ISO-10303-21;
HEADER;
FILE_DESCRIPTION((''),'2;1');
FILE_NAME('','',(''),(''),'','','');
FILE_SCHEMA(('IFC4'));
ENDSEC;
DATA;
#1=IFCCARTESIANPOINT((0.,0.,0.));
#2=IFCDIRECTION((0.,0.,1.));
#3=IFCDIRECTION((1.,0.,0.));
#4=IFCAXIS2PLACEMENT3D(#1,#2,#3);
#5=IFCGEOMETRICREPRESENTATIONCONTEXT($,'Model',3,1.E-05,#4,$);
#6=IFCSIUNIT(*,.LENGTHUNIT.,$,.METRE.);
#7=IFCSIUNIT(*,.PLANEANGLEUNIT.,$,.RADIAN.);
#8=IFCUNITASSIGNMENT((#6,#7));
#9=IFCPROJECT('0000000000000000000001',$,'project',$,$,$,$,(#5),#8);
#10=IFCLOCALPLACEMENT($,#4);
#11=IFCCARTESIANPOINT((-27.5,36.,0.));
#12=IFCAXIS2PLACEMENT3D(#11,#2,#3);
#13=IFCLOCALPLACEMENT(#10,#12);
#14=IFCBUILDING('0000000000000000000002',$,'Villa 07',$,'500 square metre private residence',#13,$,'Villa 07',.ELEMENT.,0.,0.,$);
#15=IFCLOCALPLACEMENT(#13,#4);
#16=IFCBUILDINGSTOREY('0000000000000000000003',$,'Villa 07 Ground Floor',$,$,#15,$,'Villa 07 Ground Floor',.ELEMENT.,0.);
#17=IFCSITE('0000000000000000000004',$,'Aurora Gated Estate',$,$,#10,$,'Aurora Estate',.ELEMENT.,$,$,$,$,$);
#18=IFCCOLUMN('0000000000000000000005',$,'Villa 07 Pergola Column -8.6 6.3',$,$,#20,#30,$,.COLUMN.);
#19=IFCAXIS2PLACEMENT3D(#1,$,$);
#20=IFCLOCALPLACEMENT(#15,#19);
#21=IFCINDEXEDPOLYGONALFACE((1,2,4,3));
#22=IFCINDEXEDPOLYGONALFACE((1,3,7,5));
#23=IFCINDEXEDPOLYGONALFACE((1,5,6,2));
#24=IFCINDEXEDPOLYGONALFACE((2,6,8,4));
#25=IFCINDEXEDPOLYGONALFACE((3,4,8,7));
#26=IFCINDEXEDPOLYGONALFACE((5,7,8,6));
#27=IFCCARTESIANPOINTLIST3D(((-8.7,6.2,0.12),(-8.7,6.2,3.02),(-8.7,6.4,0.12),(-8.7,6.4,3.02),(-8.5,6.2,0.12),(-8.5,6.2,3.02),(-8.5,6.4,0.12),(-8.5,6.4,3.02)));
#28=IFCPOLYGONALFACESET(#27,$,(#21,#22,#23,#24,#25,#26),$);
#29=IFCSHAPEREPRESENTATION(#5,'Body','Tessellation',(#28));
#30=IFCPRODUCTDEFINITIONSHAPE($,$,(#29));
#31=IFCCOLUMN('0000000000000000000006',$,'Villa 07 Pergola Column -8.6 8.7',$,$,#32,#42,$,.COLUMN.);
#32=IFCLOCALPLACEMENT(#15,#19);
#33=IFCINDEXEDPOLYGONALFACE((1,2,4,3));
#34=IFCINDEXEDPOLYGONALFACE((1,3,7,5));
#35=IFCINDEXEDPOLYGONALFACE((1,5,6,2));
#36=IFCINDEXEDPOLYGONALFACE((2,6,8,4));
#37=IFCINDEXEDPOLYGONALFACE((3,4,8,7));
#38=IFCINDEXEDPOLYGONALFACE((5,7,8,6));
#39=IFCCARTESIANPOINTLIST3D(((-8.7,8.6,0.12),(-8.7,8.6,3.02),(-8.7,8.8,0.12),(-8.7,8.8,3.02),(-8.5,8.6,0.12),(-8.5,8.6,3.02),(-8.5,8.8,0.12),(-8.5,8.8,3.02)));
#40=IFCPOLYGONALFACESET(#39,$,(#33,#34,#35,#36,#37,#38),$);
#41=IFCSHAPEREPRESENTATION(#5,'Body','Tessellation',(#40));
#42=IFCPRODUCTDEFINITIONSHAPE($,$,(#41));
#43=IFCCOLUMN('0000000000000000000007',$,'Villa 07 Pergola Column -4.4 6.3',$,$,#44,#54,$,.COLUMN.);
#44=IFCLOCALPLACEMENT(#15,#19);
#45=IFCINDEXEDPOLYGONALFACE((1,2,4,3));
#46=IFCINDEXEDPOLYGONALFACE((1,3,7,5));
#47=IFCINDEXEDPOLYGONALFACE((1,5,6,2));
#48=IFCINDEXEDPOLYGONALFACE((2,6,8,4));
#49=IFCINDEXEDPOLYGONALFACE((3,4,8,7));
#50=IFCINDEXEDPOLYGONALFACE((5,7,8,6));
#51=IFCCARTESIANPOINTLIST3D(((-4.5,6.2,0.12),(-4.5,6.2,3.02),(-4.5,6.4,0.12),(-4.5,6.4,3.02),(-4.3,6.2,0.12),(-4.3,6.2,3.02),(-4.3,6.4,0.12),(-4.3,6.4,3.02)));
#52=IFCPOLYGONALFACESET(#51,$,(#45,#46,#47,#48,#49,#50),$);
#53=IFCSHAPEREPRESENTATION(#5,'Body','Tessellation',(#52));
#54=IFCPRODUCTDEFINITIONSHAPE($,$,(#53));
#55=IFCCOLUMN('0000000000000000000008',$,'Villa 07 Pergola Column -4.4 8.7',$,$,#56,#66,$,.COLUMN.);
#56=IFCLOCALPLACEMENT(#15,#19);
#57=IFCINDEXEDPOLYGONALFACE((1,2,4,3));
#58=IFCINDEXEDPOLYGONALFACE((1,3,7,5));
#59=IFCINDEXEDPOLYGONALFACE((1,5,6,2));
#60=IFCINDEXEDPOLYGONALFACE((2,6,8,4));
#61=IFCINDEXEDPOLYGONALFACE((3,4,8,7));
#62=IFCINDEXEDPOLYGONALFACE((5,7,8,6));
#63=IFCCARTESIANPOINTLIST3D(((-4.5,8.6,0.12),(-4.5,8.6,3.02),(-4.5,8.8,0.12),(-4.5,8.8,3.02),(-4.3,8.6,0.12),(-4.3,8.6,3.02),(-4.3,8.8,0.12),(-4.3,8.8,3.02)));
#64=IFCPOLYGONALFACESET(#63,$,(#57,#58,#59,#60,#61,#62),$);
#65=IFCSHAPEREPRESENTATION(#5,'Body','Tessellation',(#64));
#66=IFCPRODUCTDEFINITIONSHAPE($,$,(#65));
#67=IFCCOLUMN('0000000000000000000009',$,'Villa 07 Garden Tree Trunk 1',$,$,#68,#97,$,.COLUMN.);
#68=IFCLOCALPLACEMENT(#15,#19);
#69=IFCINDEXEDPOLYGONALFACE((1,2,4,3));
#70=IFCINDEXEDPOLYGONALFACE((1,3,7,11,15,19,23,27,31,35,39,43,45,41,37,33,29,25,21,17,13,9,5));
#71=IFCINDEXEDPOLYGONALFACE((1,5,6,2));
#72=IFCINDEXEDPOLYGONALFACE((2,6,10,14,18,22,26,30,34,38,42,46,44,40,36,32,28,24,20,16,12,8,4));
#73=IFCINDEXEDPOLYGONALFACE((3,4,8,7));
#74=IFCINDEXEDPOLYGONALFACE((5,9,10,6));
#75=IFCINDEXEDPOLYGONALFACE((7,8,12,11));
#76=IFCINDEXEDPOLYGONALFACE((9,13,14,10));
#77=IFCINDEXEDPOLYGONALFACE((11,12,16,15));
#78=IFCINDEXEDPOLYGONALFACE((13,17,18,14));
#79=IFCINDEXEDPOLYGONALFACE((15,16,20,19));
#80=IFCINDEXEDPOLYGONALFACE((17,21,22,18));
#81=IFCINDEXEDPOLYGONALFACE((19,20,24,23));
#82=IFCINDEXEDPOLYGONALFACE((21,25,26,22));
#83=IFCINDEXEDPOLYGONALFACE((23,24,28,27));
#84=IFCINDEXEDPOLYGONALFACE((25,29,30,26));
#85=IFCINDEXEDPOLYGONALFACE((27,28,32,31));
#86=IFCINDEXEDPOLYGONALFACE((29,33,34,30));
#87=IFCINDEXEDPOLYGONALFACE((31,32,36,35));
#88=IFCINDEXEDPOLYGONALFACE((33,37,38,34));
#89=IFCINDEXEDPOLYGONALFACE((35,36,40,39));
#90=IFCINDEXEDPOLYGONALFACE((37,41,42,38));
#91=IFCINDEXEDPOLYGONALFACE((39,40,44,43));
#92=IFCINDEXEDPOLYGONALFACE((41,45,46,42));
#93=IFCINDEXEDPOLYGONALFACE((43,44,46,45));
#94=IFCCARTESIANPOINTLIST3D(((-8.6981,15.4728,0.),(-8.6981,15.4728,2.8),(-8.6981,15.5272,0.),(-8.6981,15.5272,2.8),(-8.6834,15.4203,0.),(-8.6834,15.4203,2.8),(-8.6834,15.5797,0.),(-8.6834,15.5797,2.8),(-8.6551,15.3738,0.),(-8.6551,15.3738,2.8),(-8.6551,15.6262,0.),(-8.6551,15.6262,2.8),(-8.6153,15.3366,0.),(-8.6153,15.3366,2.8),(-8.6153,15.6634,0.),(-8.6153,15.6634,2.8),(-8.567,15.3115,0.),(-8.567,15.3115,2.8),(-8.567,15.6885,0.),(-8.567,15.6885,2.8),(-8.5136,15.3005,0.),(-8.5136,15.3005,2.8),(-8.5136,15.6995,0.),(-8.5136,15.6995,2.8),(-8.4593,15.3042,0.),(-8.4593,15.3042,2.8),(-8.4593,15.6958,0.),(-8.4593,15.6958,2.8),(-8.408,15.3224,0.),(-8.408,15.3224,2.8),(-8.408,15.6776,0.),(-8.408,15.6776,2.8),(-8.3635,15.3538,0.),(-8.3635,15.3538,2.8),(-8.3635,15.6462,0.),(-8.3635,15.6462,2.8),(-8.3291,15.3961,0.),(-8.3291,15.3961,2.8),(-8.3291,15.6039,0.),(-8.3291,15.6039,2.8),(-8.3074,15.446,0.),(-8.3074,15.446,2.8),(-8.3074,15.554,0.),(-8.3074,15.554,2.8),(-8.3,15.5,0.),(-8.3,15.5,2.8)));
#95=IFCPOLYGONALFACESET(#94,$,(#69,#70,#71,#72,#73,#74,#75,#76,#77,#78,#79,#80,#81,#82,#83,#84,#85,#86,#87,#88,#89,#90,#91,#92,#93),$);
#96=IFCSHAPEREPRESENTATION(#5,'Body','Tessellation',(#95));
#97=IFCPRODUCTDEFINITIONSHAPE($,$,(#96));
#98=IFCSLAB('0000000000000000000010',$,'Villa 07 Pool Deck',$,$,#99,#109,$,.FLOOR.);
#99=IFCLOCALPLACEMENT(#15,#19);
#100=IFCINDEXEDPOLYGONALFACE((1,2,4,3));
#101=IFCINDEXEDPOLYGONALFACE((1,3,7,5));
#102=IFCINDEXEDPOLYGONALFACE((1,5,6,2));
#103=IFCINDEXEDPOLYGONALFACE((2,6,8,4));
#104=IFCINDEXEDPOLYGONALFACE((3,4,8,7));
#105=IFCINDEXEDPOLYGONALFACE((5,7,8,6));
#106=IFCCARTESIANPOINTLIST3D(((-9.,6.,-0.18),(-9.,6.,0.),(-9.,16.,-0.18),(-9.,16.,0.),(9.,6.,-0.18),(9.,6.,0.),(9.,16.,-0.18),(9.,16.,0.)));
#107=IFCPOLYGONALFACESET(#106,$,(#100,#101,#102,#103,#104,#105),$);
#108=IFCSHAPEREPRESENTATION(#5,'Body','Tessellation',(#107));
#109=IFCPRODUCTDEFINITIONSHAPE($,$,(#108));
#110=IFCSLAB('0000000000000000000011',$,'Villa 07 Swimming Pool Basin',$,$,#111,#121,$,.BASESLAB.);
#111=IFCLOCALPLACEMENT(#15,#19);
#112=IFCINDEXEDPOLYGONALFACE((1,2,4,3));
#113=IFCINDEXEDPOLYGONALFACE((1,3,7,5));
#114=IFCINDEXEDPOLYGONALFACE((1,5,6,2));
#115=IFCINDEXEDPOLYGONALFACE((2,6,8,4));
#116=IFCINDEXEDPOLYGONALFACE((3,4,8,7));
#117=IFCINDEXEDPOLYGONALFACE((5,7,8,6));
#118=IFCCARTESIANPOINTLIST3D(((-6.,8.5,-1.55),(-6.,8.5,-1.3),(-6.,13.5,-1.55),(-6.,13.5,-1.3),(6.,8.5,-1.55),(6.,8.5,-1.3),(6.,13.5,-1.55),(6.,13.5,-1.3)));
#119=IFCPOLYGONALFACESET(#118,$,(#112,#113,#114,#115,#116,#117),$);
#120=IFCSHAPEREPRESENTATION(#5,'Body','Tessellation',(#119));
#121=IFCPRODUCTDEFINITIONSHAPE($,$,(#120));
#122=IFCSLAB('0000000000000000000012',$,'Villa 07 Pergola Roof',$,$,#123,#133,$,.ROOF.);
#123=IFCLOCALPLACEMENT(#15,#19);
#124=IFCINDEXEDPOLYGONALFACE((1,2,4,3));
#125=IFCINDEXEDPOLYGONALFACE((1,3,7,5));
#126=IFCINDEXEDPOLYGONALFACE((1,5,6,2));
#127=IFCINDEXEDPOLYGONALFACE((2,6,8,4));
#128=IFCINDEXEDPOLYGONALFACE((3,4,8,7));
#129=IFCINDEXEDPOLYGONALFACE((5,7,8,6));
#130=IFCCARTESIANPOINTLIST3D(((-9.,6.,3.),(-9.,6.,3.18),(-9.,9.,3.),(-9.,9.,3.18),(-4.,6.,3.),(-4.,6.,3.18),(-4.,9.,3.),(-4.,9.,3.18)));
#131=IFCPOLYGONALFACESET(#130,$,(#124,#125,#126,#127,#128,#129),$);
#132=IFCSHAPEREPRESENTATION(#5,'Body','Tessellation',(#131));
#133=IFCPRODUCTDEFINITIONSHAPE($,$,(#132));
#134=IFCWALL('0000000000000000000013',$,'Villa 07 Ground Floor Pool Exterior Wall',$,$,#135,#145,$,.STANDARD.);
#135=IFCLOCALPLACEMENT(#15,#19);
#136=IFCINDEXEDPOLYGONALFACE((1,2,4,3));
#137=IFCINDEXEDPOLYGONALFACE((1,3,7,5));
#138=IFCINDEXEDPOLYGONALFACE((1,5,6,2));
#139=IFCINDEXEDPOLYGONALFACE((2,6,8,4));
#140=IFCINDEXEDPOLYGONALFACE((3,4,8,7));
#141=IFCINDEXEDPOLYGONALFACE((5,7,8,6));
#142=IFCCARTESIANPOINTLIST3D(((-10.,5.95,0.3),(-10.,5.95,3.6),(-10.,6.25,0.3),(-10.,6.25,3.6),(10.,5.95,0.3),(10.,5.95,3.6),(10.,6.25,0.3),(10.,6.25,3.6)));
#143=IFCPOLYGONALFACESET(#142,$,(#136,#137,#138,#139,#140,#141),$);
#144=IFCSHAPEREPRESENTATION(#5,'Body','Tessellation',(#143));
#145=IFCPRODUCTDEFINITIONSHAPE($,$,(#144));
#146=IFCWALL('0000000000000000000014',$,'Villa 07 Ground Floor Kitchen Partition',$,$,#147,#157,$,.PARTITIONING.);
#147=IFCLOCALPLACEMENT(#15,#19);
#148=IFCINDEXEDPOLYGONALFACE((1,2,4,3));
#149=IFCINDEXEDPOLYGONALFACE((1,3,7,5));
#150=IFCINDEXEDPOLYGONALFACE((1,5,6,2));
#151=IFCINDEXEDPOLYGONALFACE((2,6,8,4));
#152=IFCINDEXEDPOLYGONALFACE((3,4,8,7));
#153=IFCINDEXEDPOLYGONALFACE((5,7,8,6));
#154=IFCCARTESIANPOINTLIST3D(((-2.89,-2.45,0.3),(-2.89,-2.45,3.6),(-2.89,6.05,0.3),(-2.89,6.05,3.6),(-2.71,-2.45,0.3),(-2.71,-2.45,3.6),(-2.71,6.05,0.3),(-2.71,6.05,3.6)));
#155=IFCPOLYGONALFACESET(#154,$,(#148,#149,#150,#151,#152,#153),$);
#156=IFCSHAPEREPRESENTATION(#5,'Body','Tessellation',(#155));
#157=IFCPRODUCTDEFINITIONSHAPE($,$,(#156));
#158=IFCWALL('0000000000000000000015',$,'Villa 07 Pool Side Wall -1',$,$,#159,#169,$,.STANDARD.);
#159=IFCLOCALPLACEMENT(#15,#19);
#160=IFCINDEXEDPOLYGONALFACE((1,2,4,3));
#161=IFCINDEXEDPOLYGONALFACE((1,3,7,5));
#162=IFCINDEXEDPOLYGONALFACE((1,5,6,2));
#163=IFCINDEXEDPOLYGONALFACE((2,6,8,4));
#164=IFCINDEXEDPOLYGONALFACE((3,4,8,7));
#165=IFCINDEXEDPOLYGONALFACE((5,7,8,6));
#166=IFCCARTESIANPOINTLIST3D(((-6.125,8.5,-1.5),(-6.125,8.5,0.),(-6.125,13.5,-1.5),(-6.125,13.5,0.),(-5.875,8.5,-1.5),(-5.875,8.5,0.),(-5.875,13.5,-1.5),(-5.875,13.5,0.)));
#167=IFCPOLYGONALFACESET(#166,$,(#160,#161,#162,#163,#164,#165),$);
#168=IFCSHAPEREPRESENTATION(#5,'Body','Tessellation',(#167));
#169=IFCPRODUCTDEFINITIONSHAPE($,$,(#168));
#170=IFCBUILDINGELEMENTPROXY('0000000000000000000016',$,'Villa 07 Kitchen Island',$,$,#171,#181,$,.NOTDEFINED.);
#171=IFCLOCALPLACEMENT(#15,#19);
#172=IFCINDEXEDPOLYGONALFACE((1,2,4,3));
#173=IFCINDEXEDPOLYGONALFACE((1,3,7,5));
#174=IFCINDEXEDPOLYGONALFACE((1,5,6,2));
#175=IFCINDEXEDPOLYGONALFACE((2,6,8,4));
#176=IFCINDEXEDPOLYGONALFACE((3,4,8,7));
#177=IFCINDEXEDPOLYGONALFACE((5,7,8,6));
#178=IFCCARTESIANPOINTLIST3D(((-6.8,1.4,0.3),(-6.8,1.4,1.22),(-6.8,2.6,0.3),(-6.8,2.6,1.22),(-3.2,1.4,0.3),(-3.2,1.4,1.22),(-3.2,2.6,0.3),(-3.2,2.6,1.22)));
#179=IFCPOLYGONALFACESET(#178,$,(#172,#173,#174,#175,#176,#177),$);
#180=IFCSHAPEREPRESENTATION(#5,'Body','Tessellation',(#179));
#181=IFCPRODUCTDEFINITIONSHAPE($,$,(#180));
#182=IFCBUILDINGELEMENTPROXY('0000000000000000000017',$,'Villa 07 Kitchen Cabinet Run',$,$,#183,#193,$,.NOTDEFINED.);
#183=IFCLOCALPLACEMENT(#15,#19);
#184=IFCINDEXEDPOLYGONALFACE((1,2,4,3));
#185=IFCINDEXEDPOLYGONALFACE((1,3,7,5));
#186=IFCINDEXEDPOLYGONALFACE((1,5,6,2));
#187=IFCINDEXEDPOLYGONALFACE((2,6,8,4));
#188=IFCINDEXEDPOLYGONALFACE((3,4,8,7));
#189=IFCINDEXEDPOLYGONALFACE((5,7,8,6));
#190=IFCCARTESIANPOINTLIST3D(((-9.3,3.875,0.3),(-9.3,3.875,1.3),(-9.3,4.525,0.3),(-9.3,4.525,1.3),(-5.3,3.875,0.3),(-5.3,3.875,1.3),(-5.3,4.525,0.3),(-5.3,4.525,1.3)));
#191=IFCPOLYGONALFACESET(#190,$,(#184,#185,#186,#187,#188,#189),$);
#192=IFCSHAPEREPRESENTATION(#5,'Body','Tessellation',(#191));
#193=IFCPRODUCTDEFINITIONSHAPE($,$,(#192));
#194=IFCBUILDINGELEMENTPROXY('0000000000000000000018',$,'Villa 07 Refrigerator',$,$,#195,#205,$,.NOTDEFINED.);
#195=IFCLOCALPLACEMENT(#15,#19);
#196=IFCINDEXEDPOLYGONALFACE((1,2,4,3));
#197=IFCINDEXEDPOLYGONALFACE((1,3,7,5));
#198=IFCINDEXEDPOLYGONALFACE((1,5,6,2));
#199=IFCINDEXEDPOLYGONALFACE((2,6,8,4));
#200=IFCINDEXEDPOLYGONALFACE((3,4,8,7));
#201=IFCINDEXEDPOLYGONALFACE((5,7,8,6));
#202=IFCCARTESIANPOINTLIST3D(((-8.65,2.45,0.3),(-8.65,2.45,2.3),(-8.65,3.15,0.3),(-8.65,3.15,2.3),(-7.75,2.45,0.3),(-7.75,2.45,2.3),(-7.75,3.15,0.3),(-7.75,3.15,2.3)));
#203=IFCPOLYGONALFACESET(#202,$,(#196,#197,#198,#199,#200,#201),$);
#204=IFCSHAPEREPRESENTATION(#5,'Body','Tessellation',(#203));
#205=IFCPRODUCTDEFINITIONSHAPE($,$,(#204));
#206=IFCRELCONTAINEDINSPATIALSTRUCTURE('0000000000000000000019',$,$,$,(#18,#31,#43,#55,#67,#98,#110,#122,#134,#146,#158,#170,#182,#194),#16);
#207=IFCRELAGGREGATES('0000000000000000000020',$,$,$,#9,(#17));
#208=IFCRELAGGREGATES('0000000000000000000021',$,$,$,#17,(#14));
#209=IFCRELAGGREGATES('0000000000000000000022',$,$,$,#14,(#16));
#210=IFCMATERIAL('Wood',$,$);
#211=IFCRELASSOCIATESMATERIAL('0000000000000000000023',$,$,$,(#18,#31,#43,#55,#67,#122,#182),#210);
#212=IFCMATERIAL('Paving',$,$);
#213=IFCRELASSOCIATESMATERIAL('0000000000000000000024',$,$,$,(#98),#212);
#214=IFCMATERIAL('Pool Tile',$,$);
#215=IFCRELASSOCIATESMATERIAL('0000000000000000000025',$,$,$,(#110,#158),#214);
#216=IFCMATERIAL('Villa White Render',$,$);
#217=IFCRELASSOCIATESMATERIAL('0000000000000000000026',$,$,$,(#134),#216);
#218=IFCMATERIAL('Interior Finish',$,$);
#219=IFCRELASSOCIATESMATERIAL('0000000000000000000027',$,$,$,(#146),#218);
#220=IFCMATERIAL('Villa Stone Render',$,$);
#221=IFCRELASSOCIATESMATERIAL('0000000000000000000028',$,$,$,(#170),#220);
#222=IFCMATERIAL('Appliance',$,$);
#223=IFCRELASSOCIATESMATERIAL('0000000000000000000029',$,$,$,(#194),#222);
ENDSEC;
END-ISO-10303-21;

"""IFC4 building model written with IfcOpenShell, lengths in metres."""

from ifc_helpers import new_model, si_unit, frame, origin_with_axes, origin_2d_with_axis, place, context, project, spatial, rectangle, circle, extrude, material, element, save


model = new_model("IFC4")

# Units and contexts
model_context = context("Model", 3, precision=1e-05, world=origin_with_axes())
ifc_project = project(units=[si_unit("LENGTHUNIT", "METRE"), si_unit("PLANEANGLEUNIT", "RADIAN")], contexts=[model_context])

# Site, building, storey
site_placement = place(None, origin_with_axes())
site = spatial("IfcSite", under=ifc_project, at=site_placement, Name="Aurora Gated Estate", LongName="Aurora Estate", CompositionType="ELEMENT")
building_placement = place(site_placement, frame((-27.5, 36.0, 0.0), z_axis=(0.0, 0.0, 1.0), x_axis=(1.0, 0.0, 0.0)))
building = spatial("IfcBuilding", under=site, at=building_placement, Name="Villa 07", ObjectType="500 square metre private residence", LongName="Villa 07", CompositionType="ELEMENT", ElevationOfRefHeight=0.0, ElevationOfTerrain=0.0)
storey_placement = place(building_placement, origin_with_axes())
storey = spatial("IfcBuildingStorey", under=building, at=storey_placement, Name="Villa 07 Ground Floor", LongName="Villa 07 Ground Floor", CompositionType="ELEMENT", Elevation=0.0)

# Columns
ifc_material_1 = material(Name="Wood")
for number, where, z_axis, x_axis, name in (
    (1, (-8.6, 6.3, 0.12), (0.0, 0.0, 1.0), (1.0, 0.0, 0.0), "Villa 07 Pergola Column -8.6 6.3"),
    (2, (-8.6, 8.7, 0.12), (0.0, 0.0, 1.0), (1.0, 0.0, 0.0), "Villa 07 Pergola Column -8.6 8.7"),
    (3, (-4.4, 6.3, 0.12), (0.0, 0.0, 1.0), (1.0, 0.0, 0.0), "Villa 07 Pergola Column -4.4 6.3"),
    (4, (-4.4, 8.7, 0.12), (0.0, 0.0, 1.0), (1.0, 0.0, 0.0), "Villa 07 Pergola Column -4.4 8.7"),
):
    element("IfcColumn", number, at=place(storey_placement, frame(where, z_axis=z_axis, x_axis=x_axis)), inside=storey, material=ifc_material_1, Name=name, PredefinedType="COLUMN", context=model_context, shape_type="SweptSolid", body=[
        extrude(rectangle(XDim=0.2, YDim=0.2, at=origin_2d_with_axis()), origin_with_axes(), (0.0, 0.0, 1.0), 2.9),
    ])
column_placement = place(storey_placement, frame((-8.5, 15.5, 0.0), z_axis=(0.0, 0.0, 1.0), x_axis=(1.0, 0.0, 0.0)))
element("IfcColumn", 5, at=column_placement, inside=storey, material=ifc_material_1, Name="Villa 07 Garden Tree Trunk 1", PredefinedType="COLUMN", context=model_context, shape_type="SweptSolid", body=[
    extrude(circle(Radius=0.2, at=origin_2d_with_axis()), origin_with_axes(), (0.0, 0.0, 1.0), 2.8),
])

# Slabs
ifc_material_2 = material(Name="Paving")
slab_1_placement = place(storey_placement, frame((0.0, 11.0, -0.18), z_axis=(0.0, 0.0, 1.0), x_axis=(1.0, 0.0, 0.0)))
element("IfcSlab", 6, at=slab_1_placement, inside=storey, material=ifc_material_2, Name="Villa 07 Pool Deck", PredefinedType="FLOOR", context=model_context, shape_type="SweptSolid", body=[
    extrude(rectangle(XDim=18.0, YDim=10.0, at=origin_2d_with_axis()), origin_with_axes(), (0.0, 0.0, 1.0), 0.18),
])
ifc_material_3 = material(Name="Pool Tile")
slab_2_placement = place(storey_placement, frame((0.0, 11.0, -1.55), z_axis=(0.0, 0.0, 1.0), x_axis=(1.0, 0.0, 0.0)))
element("IfcSlab", 7, at=slab_2_placement, inside=storey, material=ifc_material_3, Name="Villa 07 Swimming Pool Basin", PredefinedType="BASESLAB", context=model_context, shape_type="SweptSolid", body=[
    extrude(rectangle(XDim=12.0, YDim=5.0, at=origin_2d_with_axis()), origin_with_axes(), (0.0, 0.0, 1.0), 0.25),
])
slab_3_placement = place(storey_placement, frame((-6.5, 7.5, 3.0), z_axis=(0.0, 0.0, 1.0), x_axis=(1.0, 0.0, 0.0)))
element("IfcSlab", 8, at=slab_3_placement, inside=storey, material=ifc_material_1, Name="Villa 07 Pergola Roof", PredefinedType="ROOF", context=model_context, shape_type="SweptSolid", body=[
    extrude(rectangle(XDim=5.0, YDim=3.0, at=origin_2d_with_axis()), origin_with_axes(), (0.0, 0.0, 1.0), 0.18),
])

# Walls
ifc_material_4 = material(Name="Villa White Render")
wall_1_placement = place(storey_placement, frame((0.0, 6.1, 0.3), z_axis=(0.0, 0.0, 1.0), x_axis=(1.0, 0.0, 0.0)))
element("IfcWall", 9, at=wall_1_placement, inside=storey, material=ifc_material_4, Name="Villa 07 Ground Floor Pool Exterior Wall", PredefinedType="STANDARD", context=model_context, shape_type="SweptSolid", body=[
    extrude(rectangle(XDim=20.0, YDim=0.3, at=origin_2d_with_axis()), origin_with_axes(), (0.0, 0.0, 1.0), 3.3),
])
ifc_material_5 = material(Name="Interior Finish")
wall_2_placement = place(storey_placement, frame((-2.8, 1.8, 0.3), z_axis=(0.0, 0.0, 1.0), x_axis=(1.0, 0.0, 0.0)))
element("IfcWall", 10, at=wall_2_placement, inside=storey, material=ifc_material_5, Name="Villa 07 Ground Floor Kitchen Partition", PredefinedType="PARTITIONING", context=model_context, shape_type="SweptSolid", body=[
    extrude(rectangle(XDim=0.18, YDim=8.5, at=origin_2d_with_axis()), origin_with_axes(), (0.0, 0.0, 1.0), 3.3),
])
wall_3_placement = place(storey_placement, frame((-6.0, 11.0, -1.5), z_axis=(0.0, 0.0, 1.0), x_axis=(1.0, 0.0, 0.0)))
element("IfcWall", 11, at=wall_3_placement, inside=storey, material=ifc_material_3, Name="Villa 07 Pool Side Wall -1", PredefinedType="STANDARD", context=model_context, shape_type="SweptSolid", body=[
    extrude(rectangle(XDim=0.25, YDim=5.0, at=origin_2d_with_axis()), origin_with_axes(), (0.0, 0.0, 1.0), 1.5),
])

# Building element proxies
ifc_material_6 = material(Name="Villa Stone Render")
proxy_1_placement = place(storey_placement, frame((-5.0, 2.0, 0.3), z_axis=(0.0, 0.0, 1.0), x_axis=(1.0, 0.0, 0.0)))
element("IfcBuildingElementProxy", 12, at=proxy_1_placement, inside=storey, material=ifc_material_6, Name="Villa 07 Kitchen Island", PredefinedType="NOTDEFINED", context=model_context, shape_type="SweptSolid", body=[
    extrude(rectangle(XDim=3.6, YDim=1.2, at=origin_2d_with_axis()), origin_with_axes(), (0.0, 0.0, 1.0), 0.92),
])
proxy_2_placement = place(storey_placement, frame((-7.3, 4.2, 0.3), z_axis=(0.0, 0.0, 1.0), x_axis=(1.0, 0.0, 0.0)))
element("IfcBuildingElementProxy", 13, at=proxy_2_placement, inside=storey, material=ifc_material_1, Name="Villa 07 Kitchen Cabinet Run", PredefinedType="NOTDEFINED", context=model_context, shape_type="SweptSolid", body=[
    extrude(rectangle(XDim=4.0, YDim=0.65, at=origin_2d_with_axis()), origin_with_axes(), (0.0, 0.0, 1.0), 1.0),
])
ifc_material_7 = material(Name="Appliance")
proxy_3_placement = place(storey_placement, frame((-8.2, 2.8, 0.3), z_axis=(0.0, 0.0, 1.0), x_axis=(1.0, 0.0, 0.0)))
element("IfcBuildingElementProxy", 14, at=proxy_3_placement, inside=storey, material=ifc_material_7, Name="Villa 07 Refrigerator", PredefinedType="NOTDEFINED", context=model_context, shape_type="SweptSolid", body=[
    extrude(rectangle(XDim=0.9, YDim=0.7, at=origin_2d_with_axis()), origin_with_axes(), (0.0, 0.0, 1.0), 2.0),
])

save(model, "model.ifc")
